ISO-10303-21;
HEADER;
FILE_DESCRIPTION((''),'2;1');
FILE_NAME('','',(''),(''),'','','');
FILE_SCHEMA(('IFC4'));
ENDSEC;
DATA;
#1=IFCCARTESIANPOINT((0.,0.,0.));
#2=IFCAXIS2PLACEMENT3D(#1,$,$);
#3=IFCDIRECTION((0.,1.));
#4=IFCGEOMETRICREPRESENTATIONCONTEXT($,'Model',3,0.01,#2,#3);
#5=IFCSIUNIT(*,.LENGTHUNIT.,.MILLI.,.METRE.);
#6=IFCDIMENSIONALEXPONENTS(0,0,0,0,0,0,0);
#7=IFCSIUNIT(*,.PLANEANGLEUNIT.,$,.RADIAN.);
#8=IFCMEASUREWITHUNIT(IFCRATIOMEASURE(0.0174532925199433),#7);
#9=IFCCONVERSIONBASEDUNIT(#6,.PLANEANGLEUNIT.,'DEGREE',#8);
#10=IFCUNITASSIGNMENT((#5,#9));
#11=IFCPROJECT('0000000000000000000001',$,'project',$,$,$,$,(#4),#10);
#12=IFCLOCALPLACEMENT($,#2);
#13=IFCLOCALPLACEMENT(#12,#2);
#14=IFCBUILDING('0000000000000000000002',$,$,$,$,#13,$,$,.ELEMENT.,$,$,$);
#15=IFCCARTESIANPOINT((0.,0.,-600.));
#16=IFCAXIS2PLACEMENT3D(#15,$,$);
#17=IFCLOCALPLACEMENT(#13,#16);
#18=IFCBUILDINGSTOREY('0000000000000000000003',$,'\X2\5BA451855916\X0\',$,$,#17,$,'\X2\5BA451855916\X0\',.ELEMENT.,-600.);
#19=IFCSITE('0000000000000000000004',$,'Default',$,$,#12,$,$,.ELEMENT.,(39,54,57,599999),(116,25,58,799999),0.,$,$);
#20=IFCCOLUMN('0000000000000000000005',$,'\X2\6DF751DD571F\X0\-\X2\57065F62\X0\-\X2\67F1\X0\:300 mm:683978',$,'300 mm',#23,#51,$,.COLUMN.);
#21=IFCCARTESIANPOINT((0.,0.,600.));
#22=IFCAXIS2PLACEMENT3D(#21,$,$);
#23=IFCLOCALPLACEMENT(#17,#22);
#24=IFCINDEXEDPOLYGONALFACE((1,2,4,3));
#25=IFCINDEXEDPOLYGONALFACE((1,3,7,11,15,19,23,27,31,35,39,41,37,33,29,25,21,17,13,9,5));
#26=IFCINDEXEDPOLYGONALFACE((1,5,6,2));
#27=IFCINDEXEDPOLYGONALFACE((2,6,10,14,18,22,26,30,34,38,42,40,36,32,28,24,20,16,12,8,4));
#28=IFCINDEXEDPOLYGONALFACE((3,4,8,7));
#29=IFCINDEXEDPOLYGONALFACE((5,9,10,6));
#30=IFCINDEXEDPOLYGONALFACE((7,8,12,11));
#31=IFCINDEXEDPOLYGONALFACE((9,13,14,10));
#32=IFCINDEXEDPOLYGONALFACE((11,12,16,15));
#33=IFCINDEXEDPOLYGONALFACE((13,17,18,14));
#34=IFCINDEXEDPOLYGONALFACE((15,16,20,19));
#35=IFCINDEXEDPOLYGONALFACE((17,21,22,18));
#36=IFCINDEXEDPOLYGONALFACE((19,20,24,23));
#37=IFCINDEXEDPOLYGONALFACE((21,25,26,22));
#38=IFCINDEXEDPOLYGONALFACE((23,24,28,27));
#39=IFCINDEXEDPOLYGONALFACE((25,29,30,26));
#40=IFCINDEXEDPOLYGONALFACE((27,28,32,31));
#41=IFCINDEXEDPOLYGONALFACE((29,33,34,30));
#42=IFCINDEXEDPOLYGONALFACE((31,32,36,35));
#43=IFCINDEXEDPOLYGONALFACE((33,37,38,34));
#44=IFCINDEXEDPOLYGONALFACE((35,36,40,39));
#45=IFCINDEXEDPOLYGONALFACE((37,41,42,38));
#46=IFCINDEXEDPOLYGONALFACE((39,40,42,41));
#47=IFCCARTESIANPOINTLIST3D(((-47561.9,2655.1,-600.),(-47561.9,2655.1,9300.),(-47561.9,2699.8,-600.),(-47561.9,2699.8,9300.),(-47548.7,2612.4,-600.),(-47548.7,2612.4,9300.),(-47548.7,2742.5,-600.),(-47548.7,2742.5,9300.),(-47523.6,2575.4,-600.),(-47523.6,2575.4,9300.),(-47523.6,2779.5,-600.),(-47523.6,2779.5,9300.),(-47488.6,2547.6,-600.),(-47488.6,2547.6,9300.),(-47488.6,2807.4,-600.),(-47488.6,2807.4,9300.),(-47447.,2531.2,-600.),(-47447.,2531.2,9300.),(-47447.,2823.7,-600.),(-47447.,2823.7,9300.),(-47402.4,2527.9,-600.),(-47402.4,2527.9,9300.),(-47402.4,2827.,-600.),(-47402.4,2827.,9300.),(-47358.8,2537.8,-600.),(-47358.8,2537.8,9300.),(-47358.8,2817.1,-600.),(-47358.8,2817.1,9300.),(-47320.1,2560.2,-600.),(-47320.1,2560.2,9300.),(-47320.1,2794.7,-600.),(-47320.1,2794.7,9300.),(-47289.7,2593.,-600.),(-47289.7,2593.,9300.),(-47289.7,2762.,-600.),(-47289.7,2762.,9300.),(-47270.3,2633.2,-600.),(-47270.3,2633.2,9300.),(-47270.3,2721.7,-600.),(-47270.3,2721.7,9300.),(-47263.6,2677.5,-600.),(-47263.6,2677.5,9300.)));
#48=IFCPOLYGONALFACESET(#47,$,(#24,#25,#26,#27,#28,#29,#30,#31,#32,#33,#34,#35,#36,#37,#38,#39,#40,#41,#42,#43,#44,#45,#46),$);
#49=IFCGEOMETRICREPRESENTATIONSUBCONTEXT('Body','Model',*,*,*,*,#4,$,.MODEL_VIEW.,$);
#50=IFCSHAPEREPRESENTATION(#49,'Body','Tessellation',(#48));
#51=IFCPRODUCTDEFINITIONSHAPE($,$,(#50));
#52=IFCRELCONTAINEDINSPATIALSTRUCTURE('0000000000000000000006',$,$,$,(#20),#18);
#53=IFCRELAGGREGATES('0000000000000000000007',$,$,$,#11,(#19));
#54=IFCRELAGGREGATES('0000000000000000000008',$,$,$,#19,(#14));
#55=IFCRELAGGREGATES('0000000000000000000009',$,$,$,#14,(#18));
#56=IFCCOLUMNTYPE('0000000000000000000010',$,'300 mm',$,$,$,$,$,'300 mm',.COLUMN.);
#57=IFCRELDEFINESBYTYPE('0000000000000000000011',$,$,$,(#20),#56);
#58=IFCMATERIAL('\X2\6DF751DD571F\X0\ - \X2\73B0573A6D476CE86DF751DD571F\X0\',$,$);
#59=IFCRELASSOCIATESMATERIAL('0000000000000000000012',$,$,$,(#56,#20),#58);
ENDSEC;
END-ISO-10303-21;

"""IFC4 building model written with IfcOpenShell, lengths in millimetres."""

from ifc_helpers import new_model, entity, si_unit, converted_unit, direction, frame, frame_2d, origin, place, context, subcontext, project, spatial, circle, extrude, source, transform, mapped, material, type_object, type_shapes, element, save


model = new_model("IFC4")

# Units and contexts
model_context = context("Model", 3, precision=0.01, world=origin(), true_north=direction((0.0, 1.0)))
body_context = subcontext(model_context, "Body", "Model", "MODEL_VIEW")
ifc_project = project(units=[si_unit("LENGTHUNIT", "METRE", prefix="MILLI"), converted_unit("PLANEANGLEUNIT", "DEGREE", entity("IfcRatioMeasure", 0.0174532925199433), si_unit("PLANEANGLEUNIT", "RADIAN"), dimensions=[0, 0, 0, 0, 0, 0, 0])], contexts=[model_context])

# Site, building, storey
site_placement = place(None, origin())
site = spatial("IfcSite", under=ifc_project, at=site_placement, Name="Default", CompositionType="ELEMENT", RefLatitude=(39, 54, 57, 599999), RefLongitude=(116, 25, 58, 799999), RefElevation=0.0)
building_placement = place(site_placement, origin())
building = spatial("IfcBuilding", under=site, at=building_placement, CompositionType="ELEMENT")
storey_placement = place(building_placement, frame((0.0, 0.0, -600.0)))
storey = spatial("IfcBuildingStorey", under=building, at=storey_placement, Name="室内外", LongName="室内外", CompositionType="ELEMENT", Elevation=-600.0)

# Column
ifc_material_1 = material(Name="混凝土 - 现场浇注混凝土")
column_type_1 = type_object("IfcColumnType", Name="300 mm", ElementType="300 mm", PredefinedType="COLUMN", material=ifc_material_1)
shared_shape_1 = source(origin(), body_context, "Body", "SweptSolid", [
    extrude(circle(Radius=150.0, at=frame_2d((0.0, 0.0), x_axis=(1.0, 0.0))), frame((-47413.6, 2677.5, -600.0)), (0.0, 0.0, 1.0), 9900.0),
])
type_shapes(column_type_1, [shared_shape_1])
column_1_placement = place(storey_placement, frame((0.0, 0.0, 600.0)))
element("IfcColumn", 1, at=column_1_placement, inside=storey, type_object=column_type_1, material=ifc_material_1, Name="混凝土-圆形-柱:300 mm:683978", ObjectType="300 mm", PredefinedType="COLUMN", context=body_context, shape_type="MappedRepresentation", body=[
    mapped(shared_shape_1, transform((0.0, 0.0, 0.0), scale=1.0)),
])

save(model, "model.ifc")
